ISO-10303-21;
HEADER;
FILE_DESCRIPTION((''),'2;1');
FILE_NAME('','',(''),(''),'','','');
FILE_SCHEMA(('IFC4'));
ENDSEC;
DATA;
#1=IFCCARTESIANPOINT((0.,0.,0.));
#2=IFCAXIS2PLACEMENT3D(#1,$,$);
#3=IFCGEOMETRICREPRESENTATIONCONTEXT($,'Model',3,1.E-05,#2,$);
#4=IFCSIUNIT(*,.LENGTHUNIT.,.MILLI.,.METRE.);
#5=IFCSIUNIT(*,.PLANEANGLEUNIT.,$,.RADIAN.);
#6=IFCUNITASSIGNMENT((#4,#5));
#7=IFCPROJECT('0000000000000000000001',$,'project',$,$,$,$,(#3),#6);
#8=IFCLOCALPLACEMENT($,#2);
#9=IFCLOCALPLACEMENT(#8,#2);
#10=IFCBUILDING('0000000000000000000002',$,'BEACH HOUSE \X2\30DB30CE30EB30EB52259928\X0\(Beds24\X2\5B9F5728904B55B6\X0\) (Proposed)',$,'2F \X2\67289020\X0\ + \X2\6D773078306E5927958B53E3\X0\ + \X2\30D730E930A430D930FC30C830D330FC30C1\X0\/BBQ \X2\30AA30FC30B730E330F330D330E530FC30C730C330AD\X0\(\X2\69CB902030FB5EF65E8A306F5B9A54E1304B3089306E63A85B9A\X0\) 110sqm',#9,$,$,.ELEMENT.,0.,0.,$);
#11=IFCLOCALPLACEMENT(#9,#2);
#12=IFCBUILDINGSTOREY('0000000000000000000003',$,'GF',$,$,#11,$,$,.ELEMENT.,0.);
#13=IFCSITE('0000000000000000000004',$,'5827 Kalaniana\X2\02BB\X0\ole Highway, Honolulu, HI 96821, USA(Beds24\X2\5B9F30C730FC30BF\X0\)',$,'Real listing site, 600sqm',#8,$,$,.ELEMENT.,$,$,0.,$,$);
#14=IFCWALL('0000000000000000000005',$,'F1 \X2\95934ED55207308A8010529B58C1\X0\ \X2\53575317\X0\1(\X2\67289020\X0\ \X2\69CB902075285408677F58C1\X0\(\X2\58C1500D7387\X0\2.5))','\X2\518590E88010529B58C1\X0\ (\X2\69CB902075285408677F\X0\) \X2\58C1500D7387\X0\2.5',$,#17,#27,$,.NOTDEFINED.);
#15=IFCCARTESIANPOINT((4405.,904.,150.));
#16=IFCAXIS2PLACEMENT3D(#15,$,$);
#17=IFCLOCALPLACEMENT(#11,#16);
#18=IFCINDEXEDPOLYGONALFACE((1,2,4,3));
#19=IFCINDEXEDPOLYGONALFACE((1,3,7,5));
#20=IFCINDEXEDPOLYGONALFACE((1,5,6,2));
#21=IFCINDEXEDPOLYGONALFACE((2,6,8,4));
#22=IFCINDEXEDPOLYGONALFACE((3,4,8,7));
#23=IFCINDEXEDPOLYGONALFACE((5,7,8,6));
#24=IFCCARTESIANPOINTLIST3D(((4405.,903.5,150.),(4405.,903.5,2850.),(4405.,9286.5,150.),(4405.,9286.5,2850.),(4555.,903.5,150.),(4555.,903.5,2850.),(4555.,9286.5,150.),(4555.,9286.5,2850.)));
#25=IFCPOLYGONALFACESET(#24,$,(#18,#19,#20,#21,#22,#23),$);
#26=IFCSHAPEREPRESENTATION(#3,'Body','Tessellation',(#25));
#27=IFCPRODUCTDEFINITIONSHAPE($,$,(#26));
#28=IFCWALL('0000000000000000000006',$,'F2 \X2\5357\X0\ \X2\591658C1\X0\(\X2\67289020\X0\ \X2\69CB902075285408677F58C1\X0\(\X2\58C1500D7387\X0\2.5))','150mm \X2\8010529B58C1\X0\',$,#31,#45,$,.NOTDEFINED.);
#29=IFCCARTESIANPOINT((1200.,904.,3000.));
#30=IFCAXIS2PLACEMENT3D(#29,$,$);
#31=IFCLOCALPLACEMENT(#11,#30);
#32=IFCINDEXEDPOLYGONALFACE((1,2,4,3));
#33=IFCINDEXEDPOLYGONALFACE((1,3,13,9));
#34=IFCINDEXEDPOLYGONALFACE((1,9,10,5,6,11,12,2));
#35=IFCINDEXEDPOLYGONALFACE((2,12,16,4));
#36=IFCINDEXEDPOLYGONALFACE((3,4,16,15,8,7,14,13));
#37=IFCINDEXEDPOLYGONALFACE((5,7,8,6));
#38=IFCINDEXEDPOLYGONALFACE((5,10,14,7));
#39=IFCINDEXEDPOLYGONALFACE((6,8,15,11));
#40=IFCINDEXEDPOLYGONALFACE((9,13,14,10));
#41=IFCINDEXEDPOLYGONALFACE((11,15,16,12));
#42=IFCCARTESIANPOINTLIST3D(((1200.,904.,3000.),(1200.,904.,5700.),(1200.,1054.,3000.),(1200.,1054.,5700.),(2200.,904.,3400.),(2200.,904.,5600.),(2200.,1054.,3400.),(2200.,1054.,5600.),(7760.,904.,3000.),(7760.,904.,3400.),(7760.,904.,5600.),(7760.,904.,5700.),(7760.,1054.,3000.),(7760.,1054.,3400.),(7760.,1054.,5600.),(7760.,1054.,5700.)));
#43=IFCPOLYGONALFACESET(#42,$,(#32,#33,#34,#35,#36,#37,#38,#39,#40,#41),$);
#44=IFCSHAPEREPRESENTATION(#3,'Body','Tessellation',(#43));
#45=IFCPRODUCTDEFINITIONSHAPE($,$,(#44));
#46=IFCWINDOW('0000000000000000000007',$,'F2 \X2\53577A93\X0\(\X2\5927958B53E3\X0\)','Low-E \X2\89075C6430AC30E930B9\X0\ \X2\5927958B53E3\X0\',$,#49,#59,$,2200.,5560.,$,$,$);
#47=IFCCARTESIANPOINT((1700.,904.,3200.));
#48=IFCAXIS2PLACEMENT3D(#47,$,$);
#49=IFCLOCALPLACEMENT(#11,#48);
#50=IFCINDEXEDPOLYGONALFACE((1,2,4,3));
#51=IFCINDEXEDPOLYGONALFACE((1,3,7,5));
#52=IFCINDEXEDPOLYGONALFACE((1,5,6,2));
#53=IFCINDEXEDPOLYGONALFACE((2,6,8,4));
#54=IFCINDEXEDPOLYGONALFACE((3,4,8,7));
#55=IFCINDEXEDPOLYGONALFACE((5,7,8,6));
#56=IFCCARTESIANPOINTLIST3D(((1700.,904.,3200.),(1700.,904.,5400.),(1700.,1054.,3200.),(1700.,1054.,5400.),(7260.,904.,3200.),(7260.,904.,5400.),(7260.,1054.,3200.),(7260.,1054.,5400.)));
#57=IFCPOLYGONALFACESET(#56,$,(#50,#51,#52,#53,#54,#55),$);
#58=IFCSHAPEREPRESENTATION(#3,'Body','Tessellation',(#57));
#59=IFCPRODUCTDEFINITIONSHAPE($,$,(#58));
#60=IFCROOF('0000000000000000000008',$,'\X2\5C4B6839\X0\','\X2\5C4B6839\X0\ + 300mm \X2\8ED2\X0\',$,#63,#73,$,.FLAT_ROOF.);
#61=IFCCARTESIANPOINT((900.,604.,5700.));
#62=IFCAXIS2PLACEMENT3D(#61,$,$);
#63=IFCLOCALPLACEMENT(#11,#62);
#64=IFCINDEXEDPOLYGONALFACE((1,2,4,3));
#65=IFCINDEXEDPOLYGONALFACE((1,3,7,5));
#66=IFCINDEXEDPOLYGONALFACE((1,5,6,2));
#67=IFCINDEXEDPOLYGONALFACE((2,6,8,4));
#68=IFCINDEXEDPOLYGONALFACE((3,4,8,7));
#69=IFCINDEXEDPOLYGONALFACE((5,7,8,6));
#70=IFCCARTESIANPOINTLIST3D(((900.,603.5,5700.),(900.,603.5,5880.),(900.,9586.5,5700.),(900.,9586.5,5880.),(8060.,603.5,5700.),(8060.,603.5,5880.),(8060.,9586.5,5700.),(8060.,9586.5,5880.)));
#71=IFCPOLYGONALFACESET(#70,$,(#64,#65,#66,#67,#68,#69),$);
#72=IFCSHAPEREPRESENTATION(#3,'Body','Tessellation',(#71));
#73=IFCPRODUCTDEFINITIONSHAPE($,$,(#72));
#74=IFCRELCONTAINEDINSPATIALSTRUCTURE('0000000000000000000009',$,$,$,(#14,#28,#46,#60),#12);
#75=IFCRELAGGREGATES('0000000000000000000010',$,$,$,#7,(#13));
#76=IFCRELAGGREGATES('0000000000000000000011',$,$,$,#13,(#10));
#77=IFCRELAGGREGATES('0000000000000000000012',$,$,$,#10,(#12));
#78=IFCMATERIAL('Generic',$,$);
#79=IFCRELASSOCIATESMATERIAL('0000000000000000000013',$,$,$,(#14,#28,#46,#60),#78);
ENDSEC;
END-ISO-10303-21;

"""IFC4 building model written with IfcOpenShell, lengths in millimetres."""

from ifc_helpers import new_model, si_unit, frame, frame_2d, origin, place, context, project, spatial, rectangle, extrude, material, element, fill, save


model = new_model("IFC4")

# Units and contexts
model_context = context("Model", 3, precision=1e-05, world=origin())
ifc_project = project(units=[si_unit("LENGTHUNIT", "METRE", prefix="MILLI"), si_unit("PLANEANGLEUNIT", "RADIAN")], contexts=[model_context])

# Site, building, storey
site_placement = place(None, origin())
site = spatial("IfcSite", under=ifc_project, at=site_placement, Name="5827 Kalanianaʻole Highway, Honolulu, HI 96821, USA(Beds24実データ)", ObjectType="Real listing site, 600sqm", CompositionType="ELEMENT", RefElevation=0.0)
building_placement = place(site_placement, origin())
building = spatial("IfcBuilding", under=site, at=building_placement, Name="BEACH HOUSE ホノルル別館(Beds24実在運営) (Proposed)", ObjectType="2F 木造 + 海への大開口 + プライベートビーチ/BBQ オーシャンビューデッキ(構造・延床は定員からの推定) 110sqm", CompositionType="ELEMENT", ElevationOfRefHeight=0.0, ElevationOfTerrain=0.0)
storey_placement = place(building_placement, origin())
storey = spatial("IfcBuildingStorey", under=building, at=storey_placement, Name="GF", CompositionType="ELEMENT", Elevation=0.0)

# Shared definitions
ifc_material_1 = material(Name="Generic")

# Wall
wall_1_placement = place(storey_placement, frame((4405.0, 904.0, 150.0)))
element("IfcWall", 1, at=wall_1_placement, inside=storey, material=ifc_material_1, Name="F1 間仕切り耐力壁 南北1(木造 構造用合板壁(壁倍率2.5))", Description="内部耐力壁 (構造用合板) 壁倍率2.5", PredefinedType="NOTDEFINED", context=model_context, shape_type="SweptSolid", body=[
    extrude(rectangle(XDim=150.0, YDim=8383.0, at=frame_2d((75.0, 4191.0))), frame((4405.0, 904.0, 150.0)), (0.0, 0.0, 1.0), 2700.0),
])

# Wall, opening, window
wall_2_placement = place(storey_placement, frame((1200.0, 904.0, 3000.0)))
wall_2 = element("IfcWall", 2, at=wall_2_placement, inside=storey, material=ifc_material_1, Name="F2 南 外壁(木造 構造用合板壁(壁倍率2.5))", Description="150mm 耐力壁", PredefinedType="NOTDEFINED", context=model_context, shape_type="SweptSolid", body=[
    extrude(rectangle(XDim=6560.0, YDim=150.0, at=frame_2d((3280.0, 75.0))), frame((1200.0, 904.0, 3000.0)), (0.0, 0.0, 1.0), 2700.0),
])
opening_1_placement = place(storey_placement, frame((1700.0, 904.0, 3200.0)))
opening_1 = element("IfcOpeningElement", 3, at=opening_1_placement, cuts=wall_2, PredefinedType="NOTDEFINED", context=model_context, shape_type="SweptSolid", body=[
    extrude(rectangle(XDim=5560.0, YDim=150.0, at=frame_2d((2780.0, 75.0))), frame((1700.0, 904.0, 3200.0)), (0.0, 0.0, 1.0), 2200.0),
])
window_1_placement = place(storey_placement, frame((1700.0, 904.0, 3200.0)))
window_1 = element("IfcWindow", 4, at=window_1_placement, inside=storey, material=ifc_material_1, Name="F2 南窓(大開口)", Description="Low-E 複層ガラス 大開口", OverallHeight=2200.0, OverallWidth=5560.0, context=model_context, shape_type="SweptSolid", body=[
    extrude(rectangle(XDim=5560.0, YDim=150.0, at=frame_2d((2780.0, 75.0))), frame((1700.0, 904.0, 3200.0)), (0.0, 0.0, 1.0), 2200.0),
])
fill(opening_1, window_1)

# Roof
roof_placement = place(storey_placement, frame((900.0, 604.0, 5700.0)))
element("IfcRoof", 5, at=roof_placement, inside=storey, material=ifc_material_1, Name="屋根", Description="屋根 + 300mm 軒", PredefinedType="FLAT_ROOF", context=model_context, shape_type="SweptSolid", body=[
    extrude(rectangle(XDim=7160.0, YDim=8983.0, at=frame_2d((3580.0, 4491.0))), frame((900.0, 604.0, 5700.0)), (0.0, 0.0, 1.0), 180.0),
])

save(model, "model.ifc")
